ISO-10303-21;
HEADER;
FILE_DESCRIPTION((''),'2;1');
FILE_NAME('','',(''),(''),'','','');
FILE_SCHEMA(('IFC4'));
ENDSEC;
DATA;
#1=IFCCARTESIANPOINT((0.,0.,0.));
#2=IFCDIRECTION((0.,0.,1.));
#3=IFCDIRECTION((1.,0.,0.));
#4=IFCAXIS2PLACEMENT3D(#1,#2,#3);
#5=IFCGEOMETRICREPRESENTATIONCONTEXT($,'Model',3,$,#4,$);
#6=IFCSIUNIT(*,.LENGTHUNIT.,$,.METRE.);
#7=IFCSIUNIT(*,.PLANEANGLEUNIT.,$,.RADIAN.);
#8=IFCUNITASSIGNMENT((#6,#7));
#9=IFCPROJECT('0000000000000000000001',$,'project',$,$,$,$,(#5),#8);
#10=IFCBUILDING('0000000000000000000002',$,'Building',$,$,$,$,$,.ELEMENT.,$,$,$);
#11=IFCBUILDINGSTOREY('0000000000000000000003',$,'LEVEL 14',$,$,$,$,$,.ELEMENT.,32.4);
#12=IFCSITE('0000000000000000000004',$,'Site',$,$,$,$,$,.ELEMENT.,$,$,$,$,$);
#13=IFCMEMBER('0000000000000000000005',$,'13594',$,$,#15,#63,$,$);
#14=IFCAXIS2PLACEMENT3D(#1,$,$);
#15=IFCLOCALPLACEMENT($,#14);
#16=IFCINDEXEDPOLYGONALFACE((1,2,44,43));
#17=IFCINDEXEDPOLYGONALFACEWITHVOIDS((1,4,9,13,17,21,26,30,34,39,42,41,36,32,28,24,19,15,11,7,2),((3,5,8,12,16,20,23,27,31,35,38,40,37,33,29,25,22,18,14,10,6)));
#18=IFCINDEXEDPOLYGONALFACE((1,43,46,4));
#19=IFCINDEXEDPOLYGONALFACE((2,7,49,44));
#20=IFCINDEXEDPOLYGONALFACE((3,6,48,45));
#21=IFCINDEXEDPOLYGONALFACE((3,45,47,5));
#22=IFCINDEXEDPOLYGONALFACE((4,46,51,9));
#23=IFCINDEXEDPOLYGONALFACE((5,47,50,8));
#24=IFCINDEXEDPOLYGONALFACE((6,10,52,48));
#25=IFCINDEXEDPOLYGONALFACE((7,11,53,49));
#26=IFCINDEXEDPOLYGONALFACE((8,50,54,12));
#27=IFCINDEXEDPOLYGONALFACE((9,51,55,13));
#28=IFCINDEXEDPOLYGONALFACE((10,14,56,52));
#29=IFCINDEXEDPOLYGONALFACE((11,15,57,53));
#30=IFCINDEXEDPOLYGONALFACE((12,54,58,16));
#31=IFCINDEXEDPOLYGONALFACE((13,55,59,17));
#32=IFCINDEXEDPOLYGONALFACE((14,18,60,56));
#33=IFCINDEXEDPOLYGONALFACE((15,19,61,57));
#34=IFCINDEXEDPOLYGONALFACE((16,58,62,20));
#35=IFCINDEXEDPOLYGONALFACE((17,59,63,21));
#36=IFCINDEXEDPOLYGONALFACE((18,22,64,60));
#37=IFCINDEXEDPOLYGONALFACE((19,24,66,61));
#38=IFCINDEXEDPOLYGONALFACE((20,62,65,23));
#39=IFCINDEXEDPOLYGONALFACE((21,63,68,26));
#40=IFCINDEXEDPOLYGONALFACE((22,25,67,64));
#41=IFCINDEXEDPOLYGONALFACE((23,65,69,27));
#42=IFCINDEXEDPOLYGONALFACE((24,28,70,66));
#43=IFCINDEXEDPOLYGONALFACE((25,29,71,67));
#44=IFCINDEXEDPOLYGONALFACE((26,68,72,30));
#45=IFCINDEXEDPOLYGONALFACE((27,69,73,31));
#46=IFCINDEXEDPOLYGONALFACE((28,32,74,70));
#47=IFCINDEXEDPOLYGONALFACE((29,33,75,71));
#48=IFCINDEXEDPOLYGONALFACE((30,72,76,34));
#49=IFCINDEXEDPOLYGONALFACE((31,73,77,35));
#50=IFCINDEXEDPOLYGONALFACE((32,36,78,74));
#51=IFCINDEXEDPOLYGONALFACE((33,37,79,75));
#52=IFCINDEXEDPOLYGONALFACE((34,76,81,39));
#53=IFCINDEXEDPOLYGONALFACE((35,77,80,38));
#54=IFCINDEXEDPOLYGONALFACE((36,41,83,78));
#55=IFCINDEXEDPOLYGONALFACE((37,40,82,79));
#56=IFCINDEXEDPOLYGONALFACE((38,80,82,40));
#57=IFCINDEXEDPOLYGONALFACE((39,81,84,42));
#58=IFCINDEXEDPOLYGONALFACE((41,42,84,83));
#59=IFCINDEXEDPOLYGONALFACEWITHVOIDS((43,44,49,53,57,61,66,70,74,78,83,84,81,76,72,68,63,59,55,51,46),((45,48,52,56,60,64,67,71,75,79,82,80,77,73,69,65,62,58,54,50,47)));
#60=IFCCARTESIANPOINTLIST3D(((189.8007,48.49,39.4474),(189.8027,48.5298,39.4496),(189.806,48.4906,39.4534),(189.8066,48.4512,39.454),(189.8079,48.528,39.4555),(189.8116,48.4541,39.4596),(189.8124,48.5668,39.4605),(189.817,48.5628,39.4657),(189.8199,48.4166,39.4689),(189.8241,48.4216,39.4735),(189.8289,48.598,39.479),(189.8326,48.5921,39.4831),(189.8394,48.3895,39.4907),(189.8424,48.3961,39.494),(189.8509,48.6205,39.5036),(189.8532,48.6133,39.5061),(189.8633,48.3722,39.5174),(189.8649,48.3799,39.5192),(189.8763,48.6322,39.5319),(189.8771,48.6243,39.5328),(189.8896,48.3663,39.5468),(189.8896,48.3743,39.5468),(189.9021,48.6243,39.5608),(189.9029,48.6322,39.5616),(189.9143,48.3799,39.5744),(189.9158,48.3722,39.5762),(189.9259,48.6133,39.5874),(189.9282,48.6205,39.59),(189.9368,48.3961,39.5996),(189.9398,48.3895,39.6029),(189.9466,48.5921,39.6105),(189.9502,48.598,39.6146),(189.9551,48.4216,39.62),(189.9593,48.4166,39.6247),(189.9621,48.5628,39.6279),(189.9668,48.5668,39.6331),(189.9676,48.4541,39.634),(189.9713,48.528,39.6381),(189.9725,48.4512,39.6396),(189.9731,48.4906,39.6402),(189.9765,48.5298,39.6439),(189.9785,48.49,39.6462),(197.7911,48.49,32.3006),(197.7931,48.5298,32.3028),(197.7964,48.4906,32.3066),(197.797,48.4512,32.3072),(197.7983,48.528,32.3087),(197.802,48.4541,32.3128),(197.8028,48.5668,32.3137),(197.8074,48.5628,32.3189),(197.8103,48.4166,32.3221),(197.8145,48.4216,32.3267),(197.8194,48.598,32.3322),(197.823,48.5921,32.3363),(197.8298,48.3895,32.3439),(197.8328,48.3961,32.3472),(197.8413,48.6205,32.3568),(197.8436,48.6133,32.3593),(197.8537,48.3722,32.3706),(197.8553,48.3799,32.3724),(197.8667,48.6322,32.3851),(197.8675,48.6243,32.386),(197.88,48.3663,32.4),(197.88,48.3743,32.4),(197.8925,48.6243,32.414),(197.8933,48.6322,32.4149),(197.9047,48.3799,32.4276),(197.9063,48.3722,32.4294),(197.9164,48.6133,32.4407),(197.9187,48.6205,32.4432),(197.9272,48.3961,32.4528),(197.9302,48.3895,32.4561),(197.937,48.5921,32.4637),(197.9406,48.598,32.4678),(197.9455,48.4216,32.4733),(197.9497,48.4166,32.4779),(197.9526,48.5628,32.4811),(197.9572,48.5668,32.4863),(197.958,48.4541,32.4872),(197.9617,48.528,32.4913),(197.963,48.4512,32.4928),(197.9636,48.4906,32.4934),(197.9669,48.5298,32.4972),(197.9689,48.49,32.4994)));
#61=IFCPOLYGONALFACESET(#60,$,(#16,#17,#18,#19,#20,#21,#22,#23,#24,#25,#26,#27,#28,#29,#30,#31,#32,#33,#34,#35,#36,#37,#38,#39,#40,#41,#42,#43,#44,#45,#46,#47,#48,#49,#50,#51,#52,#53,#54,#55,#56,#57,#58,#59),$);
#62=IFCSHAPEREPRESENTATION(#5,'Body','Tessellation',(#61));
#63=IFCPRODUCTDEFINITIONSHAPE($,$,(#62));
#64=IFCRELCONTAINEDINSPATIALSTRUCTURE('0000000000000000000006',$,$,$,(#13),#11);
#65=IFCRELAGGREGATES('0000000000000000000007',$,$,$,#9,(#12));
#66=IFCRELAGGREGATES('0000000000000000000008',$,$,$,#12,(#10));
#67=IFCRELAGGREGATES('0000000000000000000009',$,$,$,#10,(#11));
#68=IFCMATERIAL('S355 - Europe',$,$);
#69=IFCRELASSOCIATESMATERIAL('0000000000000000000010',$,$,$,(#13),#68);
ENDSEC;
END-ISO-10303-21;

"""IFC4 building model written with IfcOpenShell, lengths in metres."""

from ifc_helpers import new_model, si_unit, frame, origin_with_axes, origin_2d_with_axis, place, context, project, spatial, hollow_circle, extrude, material, material_profile, profile_set, profile_usage, element, save


model = new_model("IFC4")

# Units and contexts
model_context = context("Model", 3, world=origin_with_axes())
ifc_project = project(units=[si_unit("LENGTHUNIT", "METRE"), si_unit("PLANEANGLEUNIT", "RADIAN")], contexts=[model_context])

# Site, building, storey
site = spatial("IfcSite", under=ifc_project, Name="Site", CompositionType="ELEMENT")
building = spatial("IfcBuilding", under=site, Name="Building", CompositionType="ELEMENT")
storey = spatial("IfcBuildingStorey", under=building, Name="LEVEL 14", CompositionType="ELEMENT", Elevation=32.4)

# Shared definitions
ifc_material = material(Name="S355 - Europe")

# Member
ifc_material_profile_1 = material_profile(ifc_material, hollow_circle(Radius=0.1337, WallThickness=0.008, at=origin_2d_with_axis()))
ifc_profile_set_1 = profile_set([ifc_material_profile_1])
ifc_profile_usage_1 = profile_usage(ifc_profile_set_1, cardinal=10)
member_1_placement = place(None, frame((197.88, 48.5, 32.4), z_axis=(-0.745359, 0.0, 0.666663), x_axis=(0.0, -1.0, 0.0)))
element("IfcMember", 1, at=member_1_placement, inside=storey, material=ifc_profile_usage_1, Name="13594", context=model_context, shape_type="SweptSolid", body=[
    extrude(hollow_circle(Radius=0.1337, WallThickness=0.008, at=origin_2d_with_axis()), origin_with_axes(), (0.0, 0.0, 1.0), 10.7202),
])

save(model, "model.ifc")
